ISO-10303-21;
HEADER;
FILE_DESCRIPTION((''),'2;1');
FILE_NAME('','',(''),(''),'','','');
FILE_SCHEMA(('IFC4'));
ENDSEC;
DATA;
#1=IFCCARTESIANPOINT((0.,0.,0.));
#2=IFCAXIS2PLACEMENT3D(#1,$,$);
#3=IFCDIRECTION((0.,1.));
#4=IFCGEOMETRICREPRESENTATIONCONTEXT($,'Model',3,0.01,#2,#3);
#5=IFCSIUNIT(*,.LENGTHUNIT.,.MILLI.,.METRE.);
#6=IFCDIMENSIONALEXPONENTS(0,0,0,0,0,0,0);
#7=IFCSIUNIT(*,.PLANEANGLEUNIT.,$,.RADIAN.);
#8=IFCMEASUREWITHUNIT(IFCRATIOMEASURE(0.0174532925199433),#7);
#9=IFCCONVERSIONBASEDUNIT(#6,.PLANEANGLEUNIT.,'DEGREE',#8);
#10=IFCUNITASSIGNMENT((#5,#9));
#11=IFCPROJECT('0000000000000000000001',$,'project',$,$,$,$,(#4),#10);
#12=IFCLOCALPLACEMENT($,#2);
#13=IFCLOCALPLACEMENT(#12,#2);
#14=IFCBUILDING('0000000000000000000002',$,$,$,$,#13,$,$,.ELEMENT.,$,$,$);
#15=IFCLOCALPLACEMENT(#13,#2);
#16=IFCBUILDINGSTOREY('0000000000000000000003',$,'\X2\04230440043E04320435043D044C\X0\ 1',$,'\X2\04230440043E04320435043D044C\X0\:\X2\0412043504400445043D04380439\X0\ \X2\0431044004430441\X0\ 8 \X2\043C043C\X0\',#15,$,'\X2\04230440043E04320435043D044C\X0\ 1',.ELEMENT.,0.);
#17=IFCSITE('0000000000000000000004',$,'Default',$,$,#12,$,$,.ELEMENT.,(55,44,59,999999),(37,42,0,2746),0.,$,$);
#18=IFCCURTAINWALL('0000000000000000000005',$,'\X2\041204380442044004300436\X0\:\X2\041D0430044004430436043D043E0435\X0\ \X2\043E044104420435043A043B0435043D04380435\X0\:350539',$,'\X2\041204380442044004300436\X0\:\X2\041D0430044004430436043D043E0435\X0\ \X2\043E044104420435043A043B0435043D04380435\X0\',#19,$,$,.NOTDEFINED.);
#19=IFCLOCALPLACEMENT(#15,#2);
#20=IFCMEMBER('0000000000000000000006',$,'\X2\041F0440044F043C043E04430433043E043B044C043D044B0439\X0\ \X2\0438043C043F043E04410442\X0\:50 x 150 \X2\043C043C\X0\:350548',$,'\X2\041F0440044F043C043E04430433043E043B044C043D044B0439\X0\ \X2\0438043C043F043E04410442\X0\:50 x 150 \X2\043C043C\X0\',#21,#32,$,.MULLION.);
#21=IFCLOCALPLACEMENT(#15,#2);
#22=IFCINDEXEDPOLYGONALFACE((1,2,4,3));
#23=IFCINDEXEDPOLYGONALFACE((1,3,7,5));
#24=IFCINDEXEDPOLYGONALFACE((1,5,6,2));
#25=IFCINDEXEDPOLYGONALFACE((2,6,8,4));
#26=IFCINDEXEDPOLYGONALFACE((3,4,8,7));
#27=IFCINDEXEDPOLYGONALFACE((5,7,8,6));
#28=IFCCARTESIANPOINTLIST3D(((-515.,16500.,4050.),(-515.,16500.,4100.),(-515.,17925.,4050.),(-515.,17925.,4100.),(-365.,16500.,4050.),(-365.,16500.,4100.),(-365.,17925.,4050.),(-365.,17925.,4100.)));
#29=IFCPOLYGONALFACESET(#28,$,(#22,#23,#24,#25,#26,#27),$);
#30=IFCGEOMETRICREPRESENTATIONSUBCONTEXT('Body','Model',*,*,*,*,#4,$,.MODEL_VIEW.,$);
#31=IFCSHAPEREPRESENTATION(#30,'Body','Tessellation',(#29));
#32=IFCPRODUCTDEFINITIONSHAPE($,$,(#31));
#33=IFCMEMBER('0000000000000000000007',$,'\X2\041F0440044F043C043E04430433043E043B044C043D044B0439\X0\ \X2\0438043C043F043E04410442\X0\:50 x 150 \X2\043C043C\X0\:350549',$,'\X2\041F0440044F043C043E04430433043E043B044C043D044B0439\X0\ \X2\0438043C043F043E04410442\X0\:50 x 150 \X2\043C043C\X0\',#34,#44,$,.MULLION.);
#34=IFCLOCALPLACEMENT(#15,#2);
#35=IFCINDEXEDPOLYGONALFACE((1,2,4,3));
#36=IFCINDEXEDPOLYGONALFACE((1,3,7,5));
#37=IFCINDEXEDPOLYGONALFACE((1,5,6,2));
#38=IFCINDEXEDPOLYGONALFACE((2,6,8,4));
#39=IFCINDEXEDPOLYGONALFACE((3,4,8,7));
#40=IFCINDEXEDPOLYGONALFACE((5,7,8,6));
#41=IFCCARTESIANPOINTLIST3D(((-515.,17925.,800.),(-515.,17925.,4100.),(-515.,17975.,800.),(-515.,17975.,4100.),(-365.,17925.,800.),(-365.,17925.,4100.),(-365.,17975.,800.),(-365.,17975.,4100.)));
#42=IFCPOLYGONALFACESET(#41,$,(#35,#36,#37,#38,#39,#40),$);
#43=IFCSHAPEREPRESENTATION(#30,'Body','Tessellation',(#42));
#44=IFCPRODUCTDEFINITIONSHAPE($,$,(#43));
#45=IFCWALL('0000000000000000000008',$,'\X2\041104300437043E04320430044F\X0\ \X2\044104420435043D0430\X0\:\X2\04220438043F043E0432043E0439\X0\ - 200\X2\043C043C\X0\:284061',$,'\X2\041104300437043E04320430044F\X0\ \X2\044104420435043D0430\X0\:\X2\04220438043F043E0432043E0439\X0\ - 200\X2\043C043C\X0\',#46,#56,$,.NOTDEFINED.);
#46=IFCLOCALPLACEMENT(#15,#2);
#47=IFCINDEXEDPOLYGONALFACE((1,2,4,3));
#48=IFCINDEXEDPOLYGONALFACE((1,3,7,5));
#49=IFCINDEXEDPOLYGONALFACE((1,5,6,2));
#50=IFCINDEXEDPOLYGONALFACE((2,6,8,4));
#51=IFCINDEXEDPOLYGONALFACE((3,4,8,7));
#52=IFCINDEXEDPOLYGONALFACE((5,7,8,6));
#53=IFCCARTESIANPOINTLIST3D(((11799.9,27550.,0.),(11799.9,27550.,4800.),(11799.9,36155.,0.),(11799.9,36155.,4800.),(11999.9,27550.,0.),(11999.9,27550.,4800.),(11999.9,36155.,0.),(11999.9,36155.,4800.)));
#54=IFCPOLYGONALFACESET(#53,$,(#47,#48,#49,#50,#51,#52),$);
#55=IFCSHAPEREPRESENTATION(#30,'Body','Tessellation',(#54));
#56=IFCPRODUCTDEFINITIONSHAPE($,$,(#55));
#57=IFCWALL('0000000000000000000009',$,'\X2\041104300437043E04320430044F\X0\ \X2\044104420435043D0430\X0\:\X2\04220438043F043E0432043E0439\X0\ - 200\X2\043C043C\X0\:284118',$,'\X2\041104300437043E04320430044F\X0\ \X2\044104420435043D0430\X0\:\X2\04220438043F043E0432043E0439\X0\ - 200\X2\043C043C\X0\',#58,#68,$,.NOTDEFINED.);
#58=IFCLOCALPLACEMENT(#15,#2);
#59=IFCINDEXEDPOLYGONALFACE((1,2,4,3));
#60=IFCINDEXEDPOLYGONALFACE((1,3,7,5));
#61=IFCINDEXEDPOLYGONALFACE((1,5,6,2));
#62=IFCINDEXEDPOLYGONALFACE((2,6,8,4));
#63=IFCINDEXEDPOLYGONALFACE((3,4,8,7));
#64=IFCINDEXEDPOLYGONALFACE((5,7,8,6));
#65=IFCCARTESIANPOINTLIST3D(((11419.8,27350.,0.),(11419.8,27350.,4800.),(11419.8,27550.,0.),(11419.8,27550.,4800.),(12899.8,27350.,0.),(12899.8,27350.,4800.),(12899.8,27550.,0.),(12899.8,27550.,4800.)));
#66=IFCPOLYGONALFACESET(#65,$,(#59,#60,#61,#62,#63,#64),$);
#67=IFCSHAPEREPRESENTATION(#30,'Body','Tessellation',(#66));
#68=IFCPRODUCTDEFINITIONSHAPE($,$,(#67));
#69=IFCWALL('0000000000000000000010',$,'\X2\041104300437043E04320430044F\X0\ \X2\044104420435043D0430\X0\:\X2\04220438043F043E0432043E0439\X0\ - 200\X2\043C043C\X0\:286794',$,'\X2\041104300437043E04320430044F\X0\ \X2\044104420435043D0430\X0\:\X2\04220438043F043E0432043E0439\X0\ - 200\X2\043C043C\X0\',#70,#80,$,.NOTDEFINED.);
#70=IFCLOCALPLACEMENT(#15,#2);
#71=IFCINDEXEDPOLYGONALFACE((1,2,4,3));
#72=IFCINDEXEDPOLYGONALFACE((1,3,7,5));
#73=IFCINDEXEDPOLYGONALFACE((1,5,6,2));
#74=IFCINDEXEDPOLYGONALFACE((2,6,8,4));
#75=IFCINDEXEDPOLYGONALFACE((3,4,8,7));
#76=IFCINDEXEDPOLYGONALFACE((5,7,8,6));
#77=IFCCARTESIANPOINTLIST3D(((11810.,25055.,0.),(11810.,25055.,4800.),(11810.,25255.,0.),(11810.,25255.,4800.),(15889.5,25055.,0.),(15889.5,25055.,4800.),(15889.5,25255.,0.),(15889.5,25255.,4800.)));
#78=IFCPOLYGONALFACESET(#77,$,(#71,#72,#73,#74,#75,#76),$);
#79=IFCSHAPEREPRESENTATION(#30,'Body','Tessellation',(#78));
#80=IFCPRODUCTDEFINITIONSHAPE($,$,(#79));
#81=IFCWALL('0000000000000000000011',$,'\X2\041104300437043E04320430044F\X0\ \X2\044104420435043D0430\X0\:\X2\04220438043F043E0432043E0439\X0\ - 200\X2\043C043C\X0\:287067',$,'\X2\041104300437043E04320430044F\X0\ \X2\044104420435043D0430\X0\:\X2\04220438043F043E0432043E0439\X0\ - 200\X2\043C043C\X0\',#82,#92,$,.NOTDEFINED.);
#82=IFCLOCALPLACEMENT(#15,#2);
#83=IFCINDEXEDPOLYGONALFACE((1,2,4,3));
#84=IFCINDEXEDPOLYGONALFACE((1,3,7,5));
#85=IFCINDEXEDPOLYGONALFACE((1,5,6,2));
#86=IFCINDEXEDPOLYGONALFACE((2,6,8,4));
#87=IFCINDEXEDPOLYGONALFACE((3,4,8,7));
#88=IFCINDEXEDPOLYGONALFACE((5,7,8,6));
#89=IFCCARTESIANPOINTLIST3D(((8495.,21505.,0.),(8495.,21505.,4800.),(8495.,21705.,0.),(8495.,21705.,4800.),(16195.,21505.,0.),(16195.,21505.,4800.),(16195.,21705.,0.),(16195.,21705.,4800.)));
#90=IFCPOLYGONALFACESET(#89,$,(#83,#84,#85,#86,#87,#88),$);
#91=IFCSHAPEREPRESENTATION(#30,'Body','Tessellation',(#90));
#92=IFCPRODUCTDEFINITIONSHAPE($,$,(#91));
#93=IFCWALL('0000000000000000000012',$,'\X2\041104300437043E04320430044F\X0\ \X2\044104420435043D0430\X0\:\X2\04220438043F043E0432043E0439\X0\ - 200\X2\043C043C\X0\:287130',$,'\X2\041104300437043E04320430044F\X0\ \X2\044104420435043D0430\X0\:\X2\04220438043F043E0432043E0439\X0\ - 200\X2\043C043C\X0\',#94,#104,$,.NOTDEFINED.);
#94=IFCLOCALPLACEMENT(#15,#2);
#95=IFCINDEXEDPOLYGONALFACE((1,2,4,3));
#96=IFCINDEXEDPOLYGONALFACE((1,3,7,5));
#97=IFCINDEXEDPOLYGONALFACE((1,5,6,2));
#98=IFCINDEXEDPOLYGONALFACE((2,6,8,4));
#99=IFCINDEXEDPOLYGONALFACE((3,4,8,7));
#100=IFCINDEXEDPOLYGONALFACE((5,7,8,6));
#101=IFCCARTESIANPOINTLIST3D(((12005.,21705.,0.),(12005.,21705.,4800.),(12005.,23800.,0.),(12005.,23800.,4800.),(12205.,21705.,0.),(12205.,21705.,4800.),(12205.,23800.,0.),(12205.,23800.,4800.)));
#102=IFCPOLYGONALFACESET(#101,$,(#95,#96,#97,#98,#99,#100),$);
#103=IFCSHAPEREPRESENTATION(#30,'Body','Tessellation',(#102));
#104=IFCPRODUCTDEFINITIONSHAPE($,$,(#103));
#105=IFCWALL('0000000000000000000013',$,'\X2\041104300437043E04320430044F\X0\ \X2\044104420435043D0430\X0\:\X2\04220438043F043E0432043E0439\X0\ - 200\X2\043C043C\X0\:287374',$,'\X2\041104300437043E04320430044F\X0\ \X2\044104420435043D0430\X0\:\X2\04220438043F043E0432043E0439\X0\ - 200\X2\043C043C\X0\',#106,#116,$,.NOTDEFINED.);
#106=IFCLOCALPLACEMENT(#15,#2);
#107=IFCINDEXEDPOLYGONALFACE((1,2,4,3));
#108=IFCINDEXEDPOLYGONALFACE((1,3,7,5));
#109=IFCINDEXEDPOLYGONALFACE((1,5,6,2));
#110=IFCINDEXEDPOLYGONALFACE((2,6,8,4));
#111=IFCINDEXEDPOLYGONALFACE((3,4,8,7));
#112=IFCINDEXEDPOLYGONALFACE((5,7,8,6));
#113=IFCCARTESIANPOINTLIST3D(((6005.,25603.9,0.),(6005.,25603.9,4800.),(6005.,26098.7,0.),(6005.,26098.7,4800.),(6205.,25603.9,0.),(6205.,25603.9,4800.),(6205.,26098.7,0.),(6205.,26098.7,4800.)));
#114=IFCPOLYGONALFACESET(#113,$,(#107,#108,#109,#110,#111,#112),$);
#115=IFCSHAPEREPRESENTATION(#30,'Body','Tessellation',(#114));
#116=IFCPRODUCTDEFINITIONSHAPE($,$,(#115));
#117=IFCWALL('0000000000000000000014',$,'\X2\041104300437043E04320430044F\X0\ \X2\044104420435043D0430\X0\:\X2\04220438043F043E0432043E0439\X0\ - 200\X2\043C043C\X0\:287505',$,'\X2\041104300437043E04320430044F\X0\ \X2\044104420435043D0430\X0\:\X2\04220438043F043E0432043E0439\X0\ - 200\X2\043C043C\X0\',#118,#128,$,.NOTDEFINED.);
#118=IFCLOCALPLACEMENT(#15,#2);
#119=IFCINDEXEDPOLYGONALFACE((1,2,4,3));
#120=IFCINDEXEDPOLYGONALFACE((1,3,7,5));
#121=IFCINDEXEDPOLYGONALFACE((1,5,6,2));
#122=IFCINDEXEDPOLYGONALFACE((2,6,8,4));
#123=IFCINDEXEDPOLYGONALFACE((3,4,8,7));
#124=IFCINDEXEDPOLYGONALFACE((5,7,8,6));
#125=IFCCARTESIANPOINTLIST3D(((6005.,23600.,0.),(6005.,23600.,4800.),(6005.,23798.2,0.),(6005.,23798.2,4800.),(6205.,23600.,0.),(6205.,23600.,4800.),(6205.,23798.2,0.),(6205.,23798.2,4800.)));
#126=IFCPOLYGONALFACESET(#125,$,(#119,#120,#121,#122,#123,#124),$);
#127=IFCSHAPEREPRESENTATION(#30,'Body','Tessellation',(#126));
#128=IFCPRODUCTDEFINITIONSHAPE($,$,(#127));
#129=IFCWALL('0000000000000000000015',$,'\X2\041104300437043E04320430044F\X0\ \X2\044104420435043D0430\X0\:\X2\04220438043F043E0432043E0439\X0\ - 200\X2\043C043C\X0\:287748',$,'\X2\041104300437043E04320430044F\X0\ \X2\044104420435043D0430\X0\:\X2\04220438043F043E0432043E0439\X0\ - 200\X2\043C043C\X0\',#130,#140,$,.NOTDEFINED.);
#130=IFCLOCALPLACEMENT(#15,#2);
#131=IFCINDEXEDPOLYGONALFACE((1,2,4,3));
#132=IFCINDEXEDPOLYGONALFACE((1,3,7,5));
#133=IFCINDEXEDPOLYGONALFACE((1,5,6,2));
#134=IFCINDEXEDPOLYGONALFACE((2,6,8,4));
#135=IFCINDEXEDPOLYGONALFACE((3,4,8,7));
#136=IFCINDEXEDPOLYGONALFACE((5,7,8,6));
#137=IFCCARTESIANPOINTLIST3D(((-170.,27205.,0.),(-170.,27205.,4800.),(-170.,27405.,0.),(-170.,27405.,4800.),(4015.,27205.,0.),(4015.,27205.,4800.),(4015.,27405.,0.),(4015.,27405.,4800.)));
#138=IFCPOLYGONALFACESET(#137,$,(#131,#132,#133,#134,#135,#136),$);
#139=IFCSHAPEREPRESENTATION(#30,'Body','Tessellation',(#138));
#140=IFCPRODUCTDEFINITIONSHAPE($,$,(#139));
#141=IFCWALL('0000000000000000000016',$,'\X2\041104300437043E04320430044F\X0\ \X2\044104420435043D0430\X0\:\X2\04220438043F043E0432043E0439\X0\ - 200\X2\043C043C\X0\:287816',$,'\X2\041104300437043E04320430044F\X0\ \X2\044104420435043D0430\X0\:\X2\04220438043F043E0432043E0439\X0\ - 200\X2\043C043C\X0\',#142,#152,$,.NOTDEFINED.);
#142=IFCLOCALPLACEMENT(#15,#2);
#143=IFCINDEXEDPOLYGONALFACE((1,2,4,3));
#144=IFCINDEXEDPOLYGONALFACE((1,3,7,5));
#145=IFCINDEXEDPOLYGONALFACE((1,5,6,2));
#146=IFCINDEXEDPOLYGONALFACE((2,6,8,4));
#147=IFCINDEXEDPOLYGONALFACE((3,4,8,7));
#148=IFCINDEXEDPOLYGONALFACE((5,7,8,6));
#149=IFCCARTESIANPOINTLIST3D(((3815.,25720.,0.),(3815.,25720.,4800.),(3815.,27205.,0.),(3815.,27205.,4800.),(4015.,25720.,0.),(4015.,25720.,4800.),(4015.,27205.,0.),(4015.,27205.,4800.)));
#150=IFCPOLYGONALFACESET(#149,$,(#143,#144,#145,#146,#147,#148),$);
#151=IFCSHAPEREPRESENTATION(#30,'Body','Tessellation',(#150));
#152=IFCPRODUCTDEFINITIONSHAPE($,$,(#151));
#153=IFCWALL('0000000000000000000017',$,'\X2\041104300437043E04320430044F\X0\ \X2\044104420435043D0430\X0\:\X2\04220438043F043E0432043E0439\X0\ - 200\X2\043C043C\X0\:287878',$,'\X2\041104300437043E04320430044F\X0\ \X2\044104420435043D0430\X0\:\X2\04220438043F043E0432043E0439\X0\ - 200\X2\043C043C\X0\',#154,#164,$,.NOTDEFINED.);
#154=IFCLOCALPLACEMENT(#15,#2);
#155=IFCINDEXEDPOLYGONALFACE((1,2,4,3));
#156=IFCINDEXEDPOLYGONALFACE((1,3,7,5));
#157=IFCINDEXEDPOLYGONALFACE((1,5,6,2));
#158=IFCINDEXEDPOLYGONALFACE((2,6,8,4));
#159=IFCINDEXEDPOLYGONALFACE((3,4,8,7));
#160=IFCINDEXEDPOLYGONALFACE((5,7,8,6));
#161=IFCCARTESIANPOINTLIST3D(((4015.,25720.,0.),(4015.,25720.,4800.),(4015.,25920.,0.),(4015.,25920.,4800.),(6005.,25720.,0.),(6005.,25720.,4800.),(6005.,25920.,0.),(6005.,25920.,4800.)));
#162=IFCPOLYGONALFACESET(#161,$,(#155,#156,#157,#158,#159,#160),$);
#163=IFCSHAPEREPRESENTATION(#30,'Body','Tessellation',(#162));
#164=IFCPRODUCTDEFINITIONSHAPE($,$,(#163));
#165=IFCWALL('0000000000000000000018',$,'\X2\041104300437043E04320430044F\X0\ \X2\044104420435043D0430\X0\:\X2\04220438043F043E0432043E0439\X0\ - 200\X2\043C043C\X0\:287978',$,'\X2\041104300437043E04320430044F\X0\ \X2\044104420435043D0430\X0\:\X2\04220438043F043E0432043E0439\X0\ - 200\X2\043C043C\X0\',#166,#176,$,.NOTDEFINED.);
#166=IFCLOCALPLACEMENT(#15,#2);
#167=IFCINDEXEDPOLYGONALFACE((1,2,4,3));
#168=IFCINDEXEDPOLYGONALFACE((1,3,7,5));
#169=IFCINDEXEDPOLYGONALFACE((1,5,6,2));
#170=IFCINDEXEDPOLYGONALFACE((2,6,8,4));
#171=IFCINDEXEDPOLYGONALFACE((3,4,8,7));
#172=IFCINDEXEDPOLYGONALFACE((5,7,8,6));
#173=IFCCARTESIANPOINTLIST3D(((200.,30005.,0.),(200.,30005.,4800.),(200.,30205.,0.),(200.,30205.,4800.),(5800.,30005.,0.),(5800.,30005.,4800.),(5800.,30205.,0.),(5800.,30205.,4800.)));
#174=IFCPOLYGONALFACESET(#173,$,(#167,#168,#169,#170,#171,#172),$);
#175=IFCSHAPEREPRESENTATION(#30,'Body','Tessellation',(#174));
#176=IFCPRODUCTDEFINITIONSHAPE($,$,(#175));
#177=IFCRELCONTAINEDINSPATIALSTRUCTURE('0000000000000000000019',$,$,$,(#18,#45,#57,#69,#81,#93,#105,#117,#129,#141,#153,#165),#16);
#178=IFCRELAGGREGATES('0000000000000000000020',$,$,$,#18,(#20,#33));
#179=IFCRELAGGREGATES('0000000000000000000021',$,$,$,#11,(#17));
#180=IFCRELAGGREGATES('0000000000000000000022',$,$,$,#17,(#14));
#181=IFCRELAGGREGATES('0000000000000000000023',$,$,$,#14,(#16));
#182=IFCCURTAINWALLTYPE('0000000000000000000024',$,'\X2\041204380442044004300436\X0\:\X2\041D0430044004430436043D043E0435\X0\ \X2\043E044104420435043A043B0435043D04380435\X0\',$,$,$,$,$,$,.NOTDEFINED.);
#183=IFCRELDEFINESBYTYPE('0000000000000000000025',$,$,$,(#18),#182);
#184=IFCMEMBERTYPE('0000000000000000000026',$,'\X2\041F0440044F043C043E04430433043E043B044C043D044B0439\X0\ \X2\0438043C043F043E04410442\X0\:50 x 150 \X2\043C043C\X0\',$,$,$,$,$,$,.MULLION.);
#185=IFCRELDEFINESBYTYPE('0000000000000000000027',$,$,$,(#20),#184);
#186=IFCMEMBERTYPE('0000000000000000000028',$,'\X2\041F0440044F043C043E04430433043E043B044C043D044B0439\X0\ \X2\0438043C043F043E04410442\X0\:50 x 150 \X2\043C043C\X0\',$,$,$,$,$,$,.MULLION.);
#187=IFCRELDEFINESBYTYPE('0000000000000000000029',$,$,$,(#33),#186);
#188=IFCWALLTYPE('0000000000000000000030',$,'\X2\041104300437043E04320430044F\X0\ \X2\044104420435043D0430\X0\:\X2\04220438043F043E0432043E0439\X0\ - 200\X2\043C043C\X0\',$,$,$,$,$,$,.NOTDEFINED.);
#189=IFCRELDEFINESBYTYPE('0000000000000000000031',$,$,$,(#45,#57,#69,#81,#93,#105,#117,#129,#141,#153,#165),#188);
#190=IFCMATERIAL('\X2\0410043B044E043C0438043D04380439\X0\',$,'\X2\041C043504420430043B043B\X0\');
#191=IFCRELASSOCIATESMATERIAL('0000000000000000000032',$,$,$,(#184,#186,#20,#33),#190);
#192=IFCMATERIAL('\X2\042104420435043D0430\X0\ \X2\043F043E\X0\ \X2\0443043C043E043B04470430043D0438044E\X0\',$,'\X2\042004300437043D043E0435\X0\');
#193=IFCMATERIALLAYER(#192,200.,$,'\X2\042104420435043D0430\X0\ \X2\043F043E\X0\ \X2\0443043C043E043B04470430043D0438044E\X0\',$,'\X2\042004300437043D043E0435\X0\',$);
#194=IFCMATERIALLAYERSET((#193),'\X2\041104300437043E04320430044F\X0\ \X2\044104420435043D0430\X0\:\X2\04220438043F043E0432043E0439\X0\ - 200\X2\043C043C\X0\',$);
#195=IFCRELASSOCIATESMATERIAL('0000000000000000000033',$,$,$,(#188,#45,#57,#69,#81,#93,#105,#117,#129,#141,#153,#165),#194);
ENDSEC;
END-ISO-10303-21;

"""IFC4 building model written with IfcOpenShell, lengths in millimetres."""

from ifc_helpers import new_model, entity, si_unit, converted_unit, direction, frame, frame_2d, origin, origin_2d_with_axis, place, context, subcontext, project, spatial, rectangle, extrude, source, transform, mapped, material, layer, layer_set, layer_usage, material_profile, profile_set, profile_usage, type_object, type_shapes, element, aggregate, save


model = new_model("IFC4")

# Units and contexts
model_context = context("Model", 3, precision=0.01, world=origin(), true_north=direction((0.0, 1.0)))
body_context = subcontext(model_context, "Body", "Model", "MODEL_VIEW")
ifc_project = project(units=[si_unit("LENGTHUNIT", "METRE", prefix="MILLI"), converted_unit("PLANEANGLEUNIT", "DEGREE", entity("IfcRatioMeasure", 0.0174532925199433), si_unit("PLANEANGLEUNIT", "RADIAN"), dimensions=[0, 0, 0, 0, 0, 0, 0])], contexts=[model_context])

# Site, building, storey
site_placement = place(None, origin())
site = spatial("IfcSite", under=ifc_project, at=site_placement, Name="Default", CompositionType="ELEMENT", RefLatitude=(55, 44, 59, 999999), RefLongitude=(37, 42, 0, 2746), RefElevation=0.0)
building_placement = place(site_placement, origin())
building = spatial("IfcBuilding", under=site, at=building_placement, CompositionType="ELEMENT")
storey_placement = place(building_placement, origin())
storey = spatial("IfcBuildingStorey", under=building, at=storey_placement, Name="Уровень 1", ObjectType="Уровень:Верхний брус 8 мм", LongName="Уровень 1", CompositionType="ELEMENT", Elevation=0.0)

# Curtain wall, members
curtain_wall_type = type_object("IfcCurtainWallType", Name="Витраж:Наружное остекление", PredefinedType="NOTDEFINED")
curtain_wall_1_placement = place(storey_placement, origin())
curtain_wall_1 = element("IfcCurtainWall", 1, at=curtain_wall_1_placement, inside=storey, type_object=curtain_wall_type, Name="Витраж:Наружное остекление:350539", ObjectType="Витраж:Наружное остекление", PredefinedType="NOTDEFINED")
ifc_material_1 = material(Name="Алюминий", Category="Металл")
ifc_material_profile = material_profile(ifc_material_1, rectangle(XDim=150.0, YDim=50.0, at=origin_2d_with_axis()), Name="50 x 150 мм")
ifc_profile_set = profile_set([ifc_material_profile], Name="50 x 150 мм")
ifc_profile_usage_1 = profile_usage(ifc_profile_set)
member_type_1 = type_object("IfcMemberType", Name="Прямоугольный импост:50 x 150 мм", PredefinedType="MULLION", material=ifc_profile_set)
shared_shape_1 = source(origin(), body_context, "Body", "SweptSolid", [
    extrude(rectangle(XDim=150.0, YDim=50.0, at=origin_2d_with_axis()), frame((-25.0, 0.0, -1425.0), z_axis=(0.0, 0.0, 1.0), x_axis=(0.0, -1.0, 0.0)), (0.0, 0.0, 1.0), 1425.0),
])
type_shapes(member_type_1, [shared_shape_1])
member_1_placement = place(storey_placement, frame((-440.0, 17925.0, 4100.0), z_axis=(0.0, 1.0, 0.0), x_axis=(0.0, 0.0, 1.0)))
member_1 = element("IfcMember", 2, at=member_1_placement, type_object=member_type_1, material=ifc_profile_usage_1, Name="Прямоугольный импост:50 x 150 мм:350548", ObjectType="Прямоугольный импост:50 x 150 мм", PredefinedType="MULLION", context=body_context, shape_type="MappedRepresentation", body=[
    mapped(shared_shape_1, transform((0.0, 0.0, 0.0), scale=1.0)),
])
ifc_profile_usage_2 = profile_usage(ifc_profile_set)
member_type_2 = type_object("IfcMemberType", Name="Прямоугольный импост:50 x 150 мм", PredefinedType="MULLION", material=ifc_profile_set)
shared_shape_2 = source(origin(), body_context, "Body", "SweptSolid", [
    extrude(rectangle(XDim=150.0, YDim=50.0, at=origin_2d_with_axis()), frame((-25.0, 0.0, -3300.0), z_axis=(0.0, 0.0, 1.0), x_axis=(0.0, -1.0, 0.0)), (0.0, 0.0, 1.0), 3300.0),
])
type_shapes(member_type_2, [shared_shape_2])
member_2_placement = place(storey_placement, frame((-440.0, 17975.0, 800.0), z_axis=(0.0, 0.0, -1.0), x_axis=(0.0, 1.0, 0.0)))
member_2 = element("IfcMember", 3, at=member_2_placement, type_object=member_type_2, material=ifc_profile_usage_2, Name="Прямоугольный импост:50 x 150 мм:350549", ObjectType="Прямоугольный импост:50 x 150 мм", PredefinedType="MULLION", context=body_context, shape_type="MappedRepresentation", body=[
    mapped(shared_shape_2, transform((0.0, 0.0, 0.0), scale=1.0)),
])
aggregate(curtain_wall_1, [member_1, member_2])

# Walls
ifc_material_2 = material(Name="Стена по умолчанию", Category="Разное")
ifc_layer_1 = layer(ifc_material_2, 200.0, Name="Стена по умолчанию", Category="Разное")
ifc_layer_set_1 = layer_set([ifc_layer_1], Name="Базовая стена:Типовой - 200мм")
ifc_layer_usage_1 = layer_usage(ifc_layer_set_1, "AXIS2", "NEGATIVE", 100.0)
wall_type_1 = type_object("IfcWallType", Name="Базовая стена:Типовой - 200мм", PredefinedType="NOTDEFINED", material=ifc_layer_set_1)
wall_1_placement = place(storey_placement, frame((11899.9, 36155.0, 0.0), z_axis=(0.0, 0.0, 1.0), x_axis=(0.0, -1.0, 0.0)))
element("IfcWall", 4, at=wall_1_placement, inside=storey, type_object=wall_type_1, material=ifc_layer_usage_1, Name="Базовая стена:Типовой - 200мм:284061", ObjectType="Базовая стена:Типовой - 200мм", PredefinedType="NOTDEFINED", context=body_context, shape_type="SweptSolid", body=[
    extrude(rectangle(XDim=8605.0, YDim=200.0, at=frame_2d((4302.5, 0.0), x_axis=(-1.0, 0.0))), origin(), (0.0, 0.0, 1.0), 4800.0),
])
ifc_layer_usage_2 = layer_usage(ifc_layer_set_1, "AXIS2", "NEGATIVE", 100.0)
wall_2_placement = place(storey_placement, frame((11419.8, 27450.0, 0.0)))
element("IfcWall", 5, at=wall_2_placement, inside=storey, type_object=wall_type_1, material=ifc_layer_usage_2, Name="Базовая стена:Типовой - 200мм:284118", ObjectType="Базовая стена:Типовой - 200мм", PredefinedType="NOTDEFINED", context=body_context, shape_type="SweptSolid", body=[
    extrude(rectangle(XDim=1480.0, YDim=200.0, at=frame_2d((740.0, 0.0), x_axis=(-1.0, 0.0))), origin(), (0.0, 0.0, 1.0), 4800.0),
])

# Walls
ifc_layer_usage_3 = layer_usage(ifc_layer_set_1, "AXIS2", "NEGATIVE", 100.0)
wall_3_placement = place(storey_placement, frame((11810.0, 25155.0, 0.0)))
element("IfcWall", 6, at=wall_3_placement, inside=storey, type_object=wall_type_1, material=ifc_layer_usage_3, Name="Базовая стена:Типовой - 200мм:286794", ObjectType="Базовая стена:Типовой - 200мм", PredefinedType="NOTDEFINED", context=body_context, shape_type="SweptSolid", body=[
    extrude(rectangle(XDim=4079.5, YDim=200.0, at=frame_2d((2039.8, 0.0), x_axis=(-1.0, 0.0))), origin(), (0.0, 0.0, 1.0), 4800.0),
])
ifc_layer_usage_4 = layer_usage(ifc_layer_set_1, "AXIS2", "NEGATIVE", 100.0)
wall_4_placement = place(storey_placement, frame((8495.0, 21605.0, 0.0)))
element("IfcWall", 7, at=wall_4_placement, inside=storey, type_object=wall_type_1, material=ifc_layer_usage_4, Name="Базовая стена:Типовой - 200мм:287067", ObjectType="Базовая стена:Типовой - 200мм", PredefinedType="NOTDEFINED", context=body_context, shape_type="SweptSolid", body=[
    extrude(rectangle(XDim=7700.0, YDim=200.0, at=frame_2d((3850.0, 0.0), x_axis=(-1.0, 0.0))), origin(), (0.0, 0.0, 1.0), 4800.0),
])
ifc_layer_usage_5 = layer_usage(ifc_layer_set_1, "AXIS2", "NEGATIVE", 100.0)
wall_5_placement = place(storey_placement, frame((12105.0, 23800.0, 0.0), z_axis=(0.0, 0.0, 1.0), x_axis=(0.0, -1.0, 0.0)))
element("IfcWall", 8, at=wall_5_placement, inside=storey, type_object=wall_type_1, material=ifc_layer_usage_5, Name="Базовая стена:Типовой - 200мм:287130", ObjectType="Базовая стена:Типовой - 200мм", PredefinedType="NOTDEFINED", context=body_context, shape_type="SweptSolid", body=[
    extrude(rectangle(XDim=2095.0, YDim=200.0, at=frame_2d((1047.5, 0.0), x_axis=(-1.0, 0.0))), origin(), (0.0, 0.0, 1.0), 4800.0),
])

# Wall
ifc_layer_usage_6 = layer_usage(ifc_layer_set_1, "AXIS2", "NEGATIVE", 100.0)
wall_6_placement = place(storey_placement, frame((6105.0, 26098.7, 0.0), z_axis=(0.0, 0.0, 1.0), x_axis=(0.0, -1.0, 0.0)))
element("IfcWall", 9, at=wall_6_placement, inside=storey, type_object=wall_type_1, material=ifc_layer_usage_6, Name="Базовая стена:Типовой - 200мм:287374", ObjectType="Базовая стена:Типовой - 200мм", PredefinedType="NOTDEFINED", context=body_context, shape_type="SweptSolid", body=[
    extrude(rectangle(XDim=494.9, YDim=200.0, at=frame_2d((247.4, 0.0), x_axis=(-1.0, 0.0))), origin(), (0.0, 0.0, 1.0), 4800.0),
])

# Wall
ifc_layer_usage_7 = layer_usage(ifc_layer_set_1, "AXIS2", "NEGATIVE", 100.0)
wall_7_placement = place(storey_placement, frame((6105.0, 23798.2, 0.0), z_axis=(0.0, 0.0, 1.0), x_axis=(0.0, -1.0, 0.0)))
element("IfcWall", 10, at=wall_7_placement, inside=storey, type_object=wall_type_1, material=ifc_layer_usage_7, Name="Базовая стена:Типовой - 200мм:287505", ObjectType="Базовая стена:Типовой - 200мм", PredefinedType="NOTDEFINED", context=body_context, shape_type="SweptSolid", body=[
    extrude(rectangle(XDim=198.2, YDim=200.0, at=frame_2d((99.1, 0.0), x_axis=(-1.0, 0.0))), origin(), (0.0, 0.0, 1.0), 4800.0),
])

# Walls
ifc_layer_usage_8 = layer_usage(ifc_layer_set_1, "AXIS2", "NEGATIVE", 100.0)
wall_8_placement = place(storey_placement, frame((-170.0, 27305.0, 0.0)))
element("IfcWall", 11, at=wall_8_placement, inside=storey, type_object=wall_type_1, material=ifc_layer_usage_8, Name="Базовая стена:Типовой - 200мм:287748", ObjectType="Базовая стена:Типовой - 200мм", PredefinedType="NOTDEFINED", context=body_context, shape_type="SweptSolid", body=[
    extrude(rectangle(XDim=4185.0, YDim=200.0, at=frame_2d((2092.5, 0.0), x_axis=(-1.0, 0.0))), origin(), (0.0, 0.0, 1.0), 4800.0),
])
ifc_layer_usage_9 = layer_usage(ifc_layer_set_1, "AXIS2", "NEGATIVE", 100.0)
wall_9_placement = place(storey_placement, frame((3915.0, 27205.0, 0.0), z_axis=(0.0, 0.0, 1.0), x_axis=(0.0, -1.0, 0.0)))
element("IfcWall", 12, at=wall_9_placement, inside=storey, type_object=wall_type_1, material=ifc_layer_usage_9, Name="Базовая стена:Типовой - 200мм:287816", ObjectType="Базовая стена:Типовой - 200мм", PredefinedType="NOTDEFINED", context=body_context, shape_type="SweptSolid", body=[
    extrude(rectangle(XDim=1485.0, YDim=200.0, at=frame_2d((742.5, 0.0), x_axis=(-1.0, 0.0))), origin(), (0.0, 0.0, 1.0), 4800.0),
])
ifc_layer_usage_10 = layer_usage(ifc_layer_set_1, "AXIS2", "NEGATIVE", 100.0)
wall_10_placement = place(storey_placement, frame((4015.0, 25820.0, 0.0)))
element("IfcWall", 13, at=wall_10_placement, inside=storey, type_object=wall_type_1, material=ifc_layer_usage_10, Name="Базовая стена:Типовой - 200мм:287878", ObjectType="Базовая стена:Типовой - 200мм", PredefinedType="NOTDEFINED", context=body_context, shape_type="SweptSolid", body=[
    extrude(rectangle(XDim=1990.0, YDim=200.0, at=frame_2d((995.0, 0.0), x_axis=(-1.0, 0.0))), origin(), (0.0, 0.0, 1.0), 4800.0),
])
ifc_layer_usage_11 = layer_usage(ifc_layer_set_1, "AXIS2", "NEGATIVE", 100.0)
wall_11_placement = place(storey_placement, frame((200.0, 30105.0, 0.0)))
element("IfcWall", 14, at=wall_11_placement, inside=storey, type_object=wall_type_1, material=ifc_layer_usage_11, Name="Базовая стена:Типовой - 200мм:287978", ObjectType="Базовая стена:Типовой - 200мм", PredefinedType="NOTDEFINED", context=body_context, shape_type="SweptSolid", body=[
    extrude(rectangle(XDim=5600.0, YDim=200.0, at=frame_2d((2800.0, 0.0), x_axis=(-1.0, 0.0))), origin(), (0.0, 0.0, 1.0), 4800.0),
])

save(model, "model.ifc")
